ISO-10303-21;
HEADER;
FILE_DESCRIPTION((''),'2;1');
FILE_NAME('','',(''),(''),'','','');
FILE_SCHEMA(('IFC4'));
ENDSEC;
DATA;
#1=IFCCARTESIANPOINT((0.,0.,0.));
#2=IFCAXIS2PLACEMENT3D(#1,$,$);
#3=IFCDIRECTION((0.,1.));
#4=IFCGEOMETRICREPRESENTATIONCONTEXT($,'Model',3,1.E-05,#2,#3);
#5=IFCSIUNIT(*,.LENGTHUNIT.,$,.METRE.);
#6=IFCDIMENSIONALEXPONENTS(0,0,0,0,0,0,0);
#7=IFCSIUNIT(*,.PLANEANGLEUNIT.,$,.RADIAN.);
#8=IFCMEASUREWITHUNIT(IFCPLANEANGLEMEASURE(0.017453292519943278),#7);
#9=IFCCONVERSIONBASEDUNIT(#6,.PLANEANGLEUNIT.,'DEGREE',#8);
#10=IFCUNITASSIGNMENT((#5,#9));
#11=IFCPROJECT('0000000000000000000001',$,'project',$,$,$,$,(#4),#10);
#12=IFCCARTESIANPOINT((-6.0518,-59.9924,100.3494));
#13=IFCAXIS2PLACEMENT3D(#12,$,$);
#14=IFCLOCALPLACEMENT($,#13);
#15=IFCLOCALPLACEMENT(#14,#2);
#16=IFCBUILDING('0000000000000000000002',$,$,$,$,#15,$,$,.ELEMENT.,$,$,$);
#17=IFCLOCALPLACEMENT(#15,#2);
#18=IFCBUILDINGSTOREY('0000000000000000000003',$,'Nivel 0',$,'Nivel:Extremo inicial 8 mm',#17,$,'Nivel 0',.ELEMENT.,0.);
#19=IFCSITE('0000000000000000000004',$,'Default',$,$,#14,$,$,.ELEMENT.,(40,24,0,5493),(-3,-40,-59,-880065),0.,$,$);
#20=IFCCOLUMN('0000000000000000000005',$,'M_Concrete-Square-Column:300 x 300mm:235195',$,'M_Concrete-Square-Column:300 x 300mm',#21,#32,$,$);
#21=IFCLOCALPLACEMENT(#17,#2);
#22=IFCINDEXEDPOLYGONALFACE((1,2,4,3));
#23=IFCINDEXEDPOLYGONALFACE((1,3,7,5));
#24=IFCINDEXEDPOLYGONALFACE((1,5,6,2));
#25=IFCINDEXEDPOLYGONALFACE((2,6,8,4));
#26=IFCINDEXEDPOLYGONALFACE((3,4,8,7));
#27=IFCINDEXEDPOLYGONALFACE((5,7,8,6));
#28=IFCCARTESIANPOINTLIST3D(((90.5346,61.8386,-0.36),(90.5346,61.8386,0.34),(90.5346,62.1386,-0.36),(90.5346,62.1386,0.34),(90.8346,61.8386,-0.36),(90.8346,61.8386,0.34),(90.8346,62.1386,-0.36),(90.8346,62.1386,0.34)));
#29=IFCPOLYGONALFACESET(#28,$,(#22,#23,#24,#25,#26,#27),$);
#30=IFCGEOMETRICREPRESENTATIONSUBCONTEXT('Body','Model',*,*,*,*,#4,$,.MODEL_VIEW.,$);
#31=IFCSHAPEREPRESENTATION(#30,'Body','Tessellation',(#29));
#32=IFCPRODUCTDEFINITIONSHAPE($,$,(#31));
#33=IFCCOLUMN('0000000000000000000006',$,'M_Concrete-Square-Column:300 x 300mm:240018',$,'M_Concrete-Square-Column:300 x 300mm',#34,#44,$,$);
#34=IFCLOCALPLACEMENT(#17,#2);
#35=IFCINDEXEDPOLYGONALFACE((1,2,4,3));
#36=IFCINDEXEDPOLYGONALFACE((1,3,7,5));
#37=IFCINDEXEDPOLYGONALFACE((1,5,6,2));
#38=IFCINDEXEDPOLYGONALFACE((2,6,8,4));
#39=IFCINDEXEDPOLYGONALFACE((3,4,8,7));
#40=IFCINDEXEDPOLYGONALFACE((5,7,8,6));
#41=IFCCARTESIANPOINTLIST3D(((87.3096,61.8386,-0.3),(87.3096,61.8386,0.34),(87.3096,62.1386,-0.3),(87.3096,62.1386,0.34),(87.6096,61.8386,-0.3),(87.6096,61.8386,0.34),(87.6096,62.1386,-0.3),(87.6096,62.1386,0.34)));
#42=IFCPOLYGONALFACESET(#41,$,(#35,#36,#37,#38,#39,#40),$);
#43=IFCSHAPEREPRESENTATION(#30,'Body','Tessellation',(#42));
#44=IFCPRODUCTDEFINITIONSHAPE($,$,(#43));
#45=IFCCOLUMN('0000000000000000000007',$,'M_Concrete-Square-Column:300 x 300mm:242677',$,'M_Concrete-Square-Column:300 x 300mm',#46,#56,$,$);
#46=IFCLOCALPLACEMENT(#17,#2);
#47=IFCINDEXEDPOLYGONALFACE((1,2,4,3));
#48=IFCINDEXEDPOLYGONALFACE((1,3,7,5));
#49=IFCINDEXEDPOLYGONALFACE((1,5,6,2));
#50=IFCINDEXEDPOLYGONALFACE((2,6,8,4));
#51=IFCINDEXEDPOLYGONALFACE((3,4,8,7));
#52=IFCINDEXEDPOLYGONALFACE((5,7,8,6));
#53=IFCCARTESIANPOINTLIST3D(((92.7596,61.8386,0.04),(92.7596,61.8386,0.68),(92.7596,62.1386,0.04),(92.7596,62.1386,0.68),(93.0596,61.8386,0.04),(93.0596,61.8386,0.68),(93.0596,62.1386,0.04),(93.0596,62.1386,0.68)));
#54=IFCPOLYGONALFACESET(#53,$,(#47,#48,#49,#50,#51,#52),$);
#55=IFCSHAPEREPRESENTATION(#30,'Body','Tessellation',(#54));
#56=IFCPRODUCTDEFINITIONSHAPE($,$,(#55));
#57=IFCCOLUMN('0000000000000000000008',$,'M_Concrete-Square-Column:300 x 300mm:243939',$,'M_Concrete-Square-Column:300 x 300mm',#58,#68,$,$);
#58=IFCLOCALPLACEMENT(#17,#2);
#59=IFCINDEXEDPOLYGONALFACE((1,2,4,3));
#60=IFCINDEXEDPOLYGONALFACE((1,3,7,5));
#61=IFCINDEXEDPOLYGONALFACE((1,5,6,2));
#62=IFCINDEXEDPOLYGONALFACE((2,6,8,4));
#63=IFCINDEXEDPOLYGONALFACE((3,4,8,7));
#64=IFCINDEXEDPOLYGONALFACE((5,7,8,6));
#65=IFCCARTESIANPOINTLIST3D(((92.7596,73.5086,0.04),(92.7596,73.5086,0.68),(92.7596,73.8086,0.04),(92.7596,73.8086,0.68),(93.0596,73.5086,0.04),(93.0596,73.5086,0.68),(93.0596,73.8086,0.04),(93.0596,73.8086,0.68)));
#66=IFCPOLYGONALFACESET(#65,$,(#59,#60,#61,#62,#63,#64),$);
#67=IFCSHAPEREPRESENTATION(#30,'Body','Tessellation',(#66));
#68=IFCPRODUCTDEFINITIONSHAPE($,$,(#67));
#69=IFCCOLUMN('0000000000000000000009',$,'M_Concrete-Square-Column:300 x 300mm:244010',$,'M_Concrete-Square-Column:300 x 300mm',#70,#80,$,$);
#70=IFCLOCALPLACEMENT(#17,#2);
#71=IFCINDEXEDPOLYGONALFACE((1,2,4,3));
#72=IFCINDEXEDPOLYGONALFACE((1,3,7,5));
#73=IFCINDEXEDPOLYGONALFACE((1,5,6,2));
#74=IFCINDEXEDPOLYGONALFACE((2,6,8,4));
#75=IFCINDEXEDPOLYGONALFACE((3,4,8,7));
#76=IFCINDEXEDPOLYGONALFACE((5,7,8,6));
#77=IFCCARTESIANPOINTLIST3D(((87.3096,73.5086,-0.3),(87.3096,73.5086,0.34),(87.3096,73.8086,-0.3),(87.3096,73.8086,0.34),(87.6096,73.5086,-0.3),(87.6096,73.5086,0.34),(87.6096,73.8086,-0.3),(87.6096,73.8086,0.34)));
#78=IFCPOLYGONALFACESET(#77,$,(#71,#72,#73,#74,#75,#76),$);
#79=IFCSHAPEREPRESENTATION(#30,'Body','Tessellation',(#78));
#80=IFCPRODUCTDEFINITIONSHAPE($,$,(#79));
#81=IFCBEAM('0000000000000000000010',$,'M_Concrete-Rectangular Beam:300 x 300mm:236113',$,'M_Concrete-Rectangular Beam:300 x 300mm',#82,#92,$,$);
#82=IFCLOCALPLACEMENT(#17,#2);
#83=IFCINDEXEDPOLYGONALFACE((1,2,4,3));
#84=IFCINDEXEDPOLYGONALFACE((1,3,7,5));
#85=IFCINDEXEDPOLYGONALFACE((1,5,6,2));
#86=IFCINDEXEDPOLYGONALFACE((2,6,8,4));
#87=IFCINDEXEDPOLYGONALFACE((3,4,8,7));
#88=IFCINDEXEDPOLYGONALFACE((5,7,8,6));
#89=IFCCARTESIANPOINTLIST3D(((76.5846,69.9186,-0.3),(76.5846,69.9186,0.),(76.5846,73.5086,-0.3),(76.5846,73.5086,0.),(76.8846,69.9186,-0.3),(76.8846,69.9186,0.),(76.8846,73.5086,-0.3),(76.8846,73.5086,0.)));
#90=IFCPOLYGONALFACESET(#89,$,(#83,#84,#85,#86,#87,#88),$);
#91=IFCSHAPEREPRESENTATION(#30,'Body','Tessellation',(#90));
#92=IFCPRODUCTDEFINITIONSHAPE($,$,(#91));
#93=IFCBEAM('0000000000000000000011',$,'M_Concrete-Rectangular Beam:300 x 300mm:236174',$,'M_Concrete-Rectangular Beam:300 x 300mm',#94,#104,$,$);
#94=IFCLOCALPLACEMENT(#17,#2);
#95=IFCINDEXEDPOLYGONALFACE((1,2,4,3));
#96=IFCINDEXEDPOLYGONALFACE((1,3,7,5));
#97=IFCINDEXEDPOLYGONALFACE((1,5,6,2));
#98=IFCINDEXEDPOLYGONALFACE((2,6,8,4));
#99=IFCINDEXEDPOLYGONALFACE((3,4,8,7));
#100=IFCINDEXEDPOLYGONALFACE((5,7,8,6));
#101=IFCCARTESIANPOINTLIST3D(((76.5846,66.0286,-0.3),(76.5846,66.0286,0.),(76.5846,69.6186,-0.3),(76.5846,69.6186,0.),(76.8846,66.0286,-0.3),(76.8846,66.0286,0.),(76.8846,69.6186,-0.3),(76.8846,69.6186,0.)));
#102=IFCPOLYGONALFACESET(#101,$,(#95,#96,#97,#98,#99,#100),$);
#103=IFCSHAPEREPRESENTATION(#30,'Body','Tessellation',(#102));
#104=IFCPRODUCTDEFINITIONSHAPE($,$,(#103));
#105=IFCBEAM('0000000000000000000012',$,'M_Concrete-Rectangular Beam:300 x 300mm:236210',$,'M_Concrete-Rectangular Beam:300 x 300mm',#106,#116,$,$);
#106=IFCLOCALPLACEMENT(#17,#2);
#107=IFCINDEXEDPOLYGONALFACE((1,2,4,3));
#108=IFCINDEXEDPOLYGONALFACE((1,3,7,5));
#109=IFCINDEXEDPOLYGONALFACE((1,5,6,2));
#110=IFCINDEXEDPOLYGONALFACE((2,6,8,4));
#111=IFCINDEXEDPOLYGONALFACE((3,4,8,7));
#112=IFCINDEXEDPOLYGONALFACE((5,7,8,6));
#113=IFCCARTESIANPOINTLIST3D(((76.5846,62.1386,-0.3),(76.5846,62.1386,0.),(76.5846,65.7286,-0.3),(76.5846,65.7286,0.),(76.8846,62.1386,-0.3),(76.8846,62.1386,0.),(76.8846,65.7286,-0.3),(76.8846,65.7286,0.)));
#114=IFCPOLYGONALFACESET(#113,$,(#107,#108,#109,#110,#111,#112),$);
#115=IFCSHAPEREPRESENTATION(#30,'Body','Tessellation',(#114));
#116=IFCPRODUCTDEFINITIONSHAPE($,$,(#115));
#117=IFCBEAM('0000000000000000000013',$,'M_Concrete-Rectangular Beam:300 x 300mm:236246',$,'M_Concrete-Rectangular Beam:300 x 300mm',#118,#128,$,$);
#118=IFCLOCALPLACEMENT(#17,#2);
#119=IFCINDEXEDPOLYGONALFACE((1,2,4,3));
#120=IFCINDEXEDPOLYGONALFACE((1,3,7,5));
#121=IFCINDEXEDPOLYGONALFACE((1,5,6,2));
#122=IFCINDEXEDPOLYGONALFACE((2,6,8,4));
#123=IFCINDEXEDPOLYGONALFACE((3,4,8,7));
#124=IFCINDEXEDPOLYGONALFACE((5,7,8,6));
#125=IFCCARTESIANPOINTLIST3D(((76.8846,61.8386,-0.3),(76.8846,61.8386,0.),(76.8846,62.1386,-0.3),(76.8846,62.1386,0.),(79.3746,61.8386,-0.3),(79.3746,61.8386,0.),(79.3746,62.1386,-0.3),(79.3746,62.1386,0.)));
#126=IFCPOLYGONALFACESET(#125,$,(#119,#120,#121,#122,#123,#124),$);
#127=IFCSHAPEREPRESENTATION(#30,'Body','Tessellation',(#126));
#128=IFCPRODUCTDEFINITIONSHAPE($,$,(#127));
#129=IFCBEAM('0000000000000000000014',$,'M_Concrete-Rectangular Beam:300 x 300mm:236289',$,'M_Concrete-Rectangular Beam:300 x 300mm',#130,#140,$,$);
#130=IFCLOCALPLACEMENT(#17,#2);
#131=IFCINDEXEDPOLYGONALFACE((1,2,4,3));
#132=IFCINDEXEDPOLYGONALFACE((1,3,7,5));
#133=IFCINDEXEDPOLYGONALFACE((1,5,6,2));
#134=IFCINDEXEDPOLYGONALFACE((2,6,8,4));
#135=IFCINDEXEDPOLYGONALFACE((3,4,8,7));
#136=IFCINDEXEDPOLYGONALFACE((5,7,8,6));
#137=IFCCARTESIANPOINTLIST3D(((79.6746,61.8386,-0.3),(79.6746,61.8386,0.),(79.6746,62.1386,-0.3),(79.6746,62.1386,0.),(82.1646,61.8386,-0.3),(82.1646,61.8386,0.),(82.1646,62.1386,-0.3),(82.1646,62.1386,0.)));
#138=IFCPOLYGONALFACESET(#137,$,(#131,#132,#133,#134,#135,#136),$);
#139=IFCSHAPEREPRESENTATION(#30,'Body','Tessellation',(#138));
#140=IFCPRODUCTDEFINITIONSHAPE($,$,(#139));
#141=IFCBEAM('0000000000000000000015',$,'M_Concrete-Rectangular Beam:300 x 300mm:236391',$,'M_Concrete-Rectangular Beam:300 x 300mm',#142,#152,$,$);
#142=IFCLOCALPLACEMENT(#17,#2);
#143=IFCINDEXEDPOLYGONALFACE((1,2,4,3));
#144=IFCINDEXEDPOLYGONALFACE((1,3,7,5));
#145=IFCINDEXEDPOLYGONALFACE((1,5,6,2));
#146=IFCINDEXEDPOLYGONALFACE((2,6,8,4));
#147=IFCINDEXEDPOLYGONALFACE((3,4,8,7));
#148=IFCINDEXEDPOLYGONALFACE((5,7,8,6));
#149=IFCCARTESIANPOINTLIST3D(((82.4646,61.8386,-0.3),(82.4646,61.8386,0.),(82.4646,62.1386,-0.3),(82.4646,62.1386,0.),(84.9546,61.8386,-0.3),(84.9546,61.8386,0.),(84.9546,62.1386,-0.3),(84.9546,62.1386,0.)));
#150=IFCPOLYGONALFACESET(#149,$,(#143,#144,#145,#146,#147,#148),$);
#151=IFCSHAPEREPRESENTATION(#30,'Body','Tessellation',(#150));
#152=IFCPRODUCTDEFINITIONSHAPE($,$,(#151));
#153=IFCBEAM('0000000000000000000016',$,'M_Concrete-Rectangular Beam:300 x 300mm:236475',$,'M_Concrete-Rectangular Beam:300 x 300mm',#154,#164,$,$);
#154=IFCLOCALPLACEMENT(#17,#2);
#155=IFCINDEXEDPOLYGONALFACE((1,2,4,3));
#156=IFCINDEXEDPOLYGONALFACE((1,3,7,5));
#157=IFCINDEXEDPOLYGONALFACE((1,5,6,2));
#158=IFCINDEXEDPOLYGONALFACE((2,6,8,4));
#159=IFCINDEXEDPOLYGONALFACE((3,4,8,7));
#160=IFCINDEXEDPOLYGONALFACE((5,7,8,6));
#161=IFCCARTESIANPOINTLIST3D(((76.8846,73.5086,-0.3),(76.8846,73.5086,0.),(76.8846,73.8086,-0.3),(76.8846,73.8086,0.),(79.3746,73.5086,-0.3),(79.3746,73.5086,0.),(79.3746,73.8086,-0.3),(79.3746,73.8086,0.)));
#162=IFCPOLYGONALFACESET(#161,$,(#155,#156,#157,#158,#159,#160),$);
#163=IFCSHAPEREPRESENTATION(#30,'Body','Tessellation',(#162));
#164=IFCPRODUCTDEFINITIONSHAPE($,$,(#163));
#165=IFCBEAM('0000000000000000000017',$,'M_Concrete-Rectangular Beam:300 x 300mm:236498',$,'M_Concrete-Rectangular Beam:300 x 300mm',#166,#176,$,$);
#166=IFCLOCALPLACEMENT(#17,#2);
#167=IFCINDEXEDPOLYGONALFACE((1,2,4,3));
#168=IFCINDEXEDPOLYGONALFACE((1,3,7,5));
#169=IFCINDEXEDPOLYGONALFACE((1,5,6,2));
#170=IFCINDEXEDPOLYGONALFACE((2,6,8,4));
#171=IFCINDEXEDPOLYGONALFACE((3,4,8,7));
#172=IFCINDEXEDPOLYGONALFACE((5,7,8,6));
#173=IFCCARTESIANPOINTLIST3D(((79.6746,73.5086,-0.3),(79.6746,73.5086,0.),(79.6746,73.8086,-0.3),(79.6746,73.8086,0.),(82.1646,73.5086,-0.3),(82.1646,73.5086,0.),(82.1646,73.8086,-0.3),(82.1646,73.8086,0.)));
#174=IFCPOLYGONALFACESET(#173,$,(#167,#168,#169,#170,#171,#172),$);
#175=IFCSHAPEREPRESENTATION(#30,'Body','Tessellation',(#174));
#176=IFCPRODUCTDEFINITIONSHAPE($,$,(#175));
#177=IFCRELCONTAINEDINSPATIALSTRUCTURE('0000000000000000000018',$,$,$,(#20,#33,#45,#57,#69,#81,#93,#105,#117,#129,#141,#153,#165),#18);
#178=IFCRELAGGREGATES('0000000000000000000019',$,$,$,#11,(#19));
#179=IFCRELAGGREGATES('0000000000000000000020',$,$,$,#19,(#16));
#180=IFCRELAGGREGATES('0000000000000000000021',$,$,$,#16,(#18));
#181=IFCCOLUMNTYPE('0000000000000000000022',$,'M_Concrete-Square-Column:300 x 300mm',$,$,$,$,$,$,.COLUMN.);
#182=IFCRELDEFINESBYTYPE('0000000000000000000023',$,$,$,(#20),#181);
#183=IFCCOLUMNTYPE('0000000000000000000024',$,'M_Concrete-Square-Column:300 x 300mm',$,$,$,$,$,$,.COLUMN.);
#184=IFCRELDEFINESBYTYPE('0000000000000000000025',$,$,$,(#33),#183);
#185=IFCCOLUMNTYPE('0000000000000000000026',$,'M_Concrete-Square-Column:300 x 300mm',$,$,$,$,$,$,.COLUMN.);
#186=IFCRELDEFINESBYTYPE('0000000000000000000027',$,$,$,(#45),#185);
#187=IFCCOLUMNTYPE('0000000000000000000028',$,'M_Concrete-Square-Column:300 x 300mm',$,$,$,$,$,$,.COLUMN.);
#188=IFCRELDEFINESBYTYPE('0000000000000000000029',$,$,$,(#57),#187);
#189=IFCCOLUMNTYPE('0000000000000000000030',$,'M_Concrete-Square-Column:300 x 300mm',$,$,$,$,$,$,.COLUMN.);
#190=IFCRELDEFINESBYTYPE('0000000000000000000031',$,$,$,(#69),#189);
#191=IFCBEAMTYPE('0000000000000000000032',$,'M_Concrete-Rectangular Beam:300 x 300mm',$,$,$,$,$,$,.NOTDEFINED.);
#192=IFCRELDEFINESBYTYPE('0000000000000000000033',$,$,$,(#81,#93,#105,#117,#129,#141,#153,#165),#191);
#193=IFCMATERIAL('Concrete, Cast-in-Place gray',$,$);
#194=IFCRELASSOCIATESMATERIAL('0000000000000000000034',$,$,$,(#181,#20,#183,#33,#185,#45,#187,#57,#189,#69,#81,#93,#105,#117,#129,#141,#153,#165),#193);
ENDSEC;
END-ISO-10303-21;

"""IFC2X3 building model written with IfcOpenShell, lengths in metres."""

from ifc_helpers import new_model, entity, si_unit, converted_unit, direction, frame, frame_2d, origin, origin_2d_with_axis, place, context, subcontext, project, spatial, rectangle, extrude, source, transform, mapped, material, type_object, type_shapes, element, save


model = new_model("IFC2X3")

# Units and contexts
model_context = context("Model", 3, precision=1e-05, world=origin(), true_north=direction((0.0, 1.0)))
body_context = subcontext(model_context, "Body", "Model", "MODEL_VIEW")
ifc_project = project(units=[si_unit("LENGTHUNIT", "METRE"), converted_unit("PLANEANGLEUNIT", "DEGREE", entity("IfcPlaneAngleMeasure", 0.017453292519943278), si_unit("PLANEANGLEUNIT", "RADIAN"), dimensions=[0, 0, 0, 0, 0, 0, 0])], contexts=[model_context])

# Site, building, storey
site_placement = place(None, frame((-6.0518, -59.9924, 100.3494)))
site = spatial("IfcSite", under=ifc_project, at=site_placement, Name="Default", CompositionType="ELEMENT", RefLatitude=(40, 24, 0, 5493), RefLongitude=(-3, -40, -59, -880065), RefElevation=0.0)
building_placement = place(site_placement, origin())
building = spatial("IfcBuilding", under=site, at=building_placement, CompositionType="ELEMENT")
storey_placement = place(building_placement, origin())
storey = spatial("IfcBuildingStorey", under=building, at=storey_placement, Name="Nivel 0", ObjectType="Nivel:Extremo inicial 8 mm", LongName="Nivel 0", CompositionType="ELEMENT", Elevation=0.0)

# Columns
ifc_material = material(Name="Concrete, Cast-in-Place gray")
column_type_1 = type_object("IfcColumnType", Name="M_Concrete-Square-Column:300 x 300mm", PredefinedType="COLUMN", material=ifc_material)
shared_shape_1 = source(origin(), body_context, "Body", "SweptSolid", [
    extrude(rectangle(XDim=0.3, YDim=0.3, at=origin_2d_with_axis()), frame((90.6846, 61.9886, -0.36), z_axis=(0.0, 0.0, 1.0), x_axis=(-1.0, 0.0, 0.0)), (0.0, 0.0, 1.0), 0.7),
])
type_shapes(column_type_1, [shared_shape_1])
column_1_placement = place(storey_placement, origin())
element("IfcColumn", 1, at=column_1_placement, inside=storey, type_object=column_type_1, material=ifc_material, Name="M_Concrete-Square-Column:300 x 300mm:235195", ObjectType="M_Concrete-Square-Column:300 x 300mm", context=body_context, shape_type="MappedRepresentation", body=[
    mapped(shared_shape_1, transform((0.0, 0.0, 0.0), scale=1.0)),
])
column_type_2 = type_object("IfcColumnType", Name="M_Concrete-Square-Column:300 x 300mm", PredefinedType="COLUMN", material=ifc_material)
shared_shape_2 = source(origin(), body_context, "Body", "SweptSolid", [
    extrude(rectangle(XDim=0.3, YDim=0.3, at=origin_2d_with_axis()), frame((87.4596, 61.9886, -0.3), z_axis=(0.0, 0.0, 1.0), x_axis=(-1.0, 0.0, 0.0)), (0.0, 0.0, 1.0), 0.64),
])
type_shapes(column_type_2, [shared_shape_2])
column_2_placement = place(storey_placement, origin())
element("IfcColumn", 2, at=column_2_placement, inside=storey, type_object=column_type_2, material=ifc_material, Name="M_Concrete-Square-Column:300 x 300mm:240018", ObjectType="M_Concrete-Square-Column:300 x 300mm", context=body_context, shape_type="MappedRepresentation", body=[
    mapped(shared_shape_2, transform((0.0, 0.0, 0.0), scale=1.0)),
])
column_type_3 = type_object("IfcColumnType", Name="M_Concrete-Square-Column:300 x 300mm", PredefinedType="COLUMN", material=ifc_material)
shared_shape_3 = source(origin(), body_context, "Body", "SweptSolid", [
    extrude(rectangle(XDim=0.3, YDim=0.3, at=origin_2d_with_axis()), frame((92.9096, 61.9886, 0.04), z_axis=(0.0, 0.0, 1.0), x_axis=(-1.0, 0.0, 0.0)), (0.0, 0.0, 1.0), 0.64),
])
type_shapes(column_type_3, [shared_shape_3])
column_3_placement = place(storey_placement, origin())
element("IfcColumn", 3, at=column_3_placement, inside=storey, type_object=column_type_3, material=ifc_material, Name="M_Concrete-Square-Column:300 x 300mm:242677", ObjectType="M_Concrete-Square-Column:300 x 300mm", context=body_context, shape_type="MappedRepresentation", body=[
    mapped(shared_shape_3, transform((0.0, 0.0, 0.0), scale=1.0)),
])
column_type_4 = type_object("IfcColumnType", Name="M_Concrete-Square-Column:300 x 300mm", PredefinedType="COLUMN", material=ifc_material)
shared_shape_4 = source(origin(), body_context, "Body", "SweptSolid", [
    extrude(rectangle(XDim=0.3, YDim=0.3, at=origin_2d_with_axis()), frame((92.9096, 73.6586, 0.04), z_axis=(0.0, 0.0, 1.0), x_axis=(-1.0, 0.0, 0.0)), (0.0, 0.0, 1.0), 0.64),
])
type_shapes(column_type_4, [shared_shape_4])
column_4_placement = place(storey_placement, origin())
element("IfcColumn", 4, at=column_4_placement, inside=storey, type_object=column_type_4, material=ifc_material, Name="M_Concrete-Square-Column:300 x 300mm:243939", ObjectType="M_Concrete-Square-Column:300 x 300mm", context=body_context, shape_type="MappedRepresentation", body=[
    mapped(shared_shape_4, transform((0.0, 0.0, 0.0), scale=1.0)),
])
column_type_5 = type_object("IfcColumnType", Name="M_Concrete-Square-Column:300 x 300mm", PredefinedType="COLUMN", material=ifc_material)
shared_shape_5 = source(origin(), body_context, "Body", "SweptSolid", [
    extrude(rectangle(XDim=0.3, YDim=0.3, at=origin_2d_with_axis()), frame((87.4596, 73.6586, -0.3), z_axis=(0.0, 0.0, 1.0), x_axis=(-1.0, 0.0, 0.0)), (0.0, 0.0, 1.0), 0.64),
])
type_shapes(column_type_5, [shared_shape_5])
column_5_placement = place(storey_placement, origin())
element("IfcColumn", 5, at=column_5_placement, inside=storey, type_object=column_type_5, material=ifc_material, Name="M_Concrete-Square-Column:300 x 300mm:244010", ObjectType="M_Concrete-Square-Column:300 x 300mm", context=body_context, shape_type="MappedRepresentation", body=[
    mapped(shared_shape_5, transform((0.0, 0.0, 0.0), scale=1.0)),
])

# Beams
beam_type = type_object("IfcBeamType", Name="M_Concrete-Rectangular Beam:300 x 300mm", PredefinedType="NOTDEFINED")
beam_1_placement = place(storey_placement, frame((76.7346, 73.6586, 0.0), z_axis=(0.0, 0.0, 1.0), x_axis=(0.0, -1.0, 0.0)))
element("IfcBeam", 6, at=beam_1_placement, inside=storey, type_object=beam_type, material=ifc_material, Name="M_Concrete-Rectangular Beam:300 x 300mm:236113", ObjectType="M_Concrete-Rectangular Beam:300 x 300mm", context=body_context, shape_type="SweptSolid", body=[
    extrude(rectangle(XDim=0.3, YDim=0.3, at=frame_2d((0.0, 0.0), x_axis=(1.0, 0.0))), frame((0.15, 0.0, -0.15), z_axis=(1.0, 0.0, 0.0), x_axis=(0.0, 0.0, -1.0)), (0.0, 0.0, 1.0), 3.59),
])
beam_2_placement = place(storey_placement, frame((76.7346, 69.7686, 0.0), z_axis=(0.0, 0.0, 1.0), x_axis=(0.0, -1.0, 0.0)))
element("IfcBeam", 7, at=beam_2_placement, inside=storey, type_object=beam_type, material=ifc_material, Name="M_Concrete-Rectangular Beam:300 x 300mm:236174", ObjectType="M_Concrete-Rectangular Beam:300 x 300mm", context=body_context, shape_type="SweptSolid", body=[
    extrude(rectangle(XDim=0.3, YDim=0.3, at=frame_2d((0.0, 0.0), x_axis=(1.0, 0.0))), frame((0.15, 0.0, -0.15), z_axis=(1.0, 0.0, 0.0), x_axis=(0.0, 0.0, -1.0)), (0.0, 0.0, 1.0), 3.59),
])
beam_3_placement = place(storey_placement, frame((76.7346, 65.8786, 0.0), z_axis=(0.0, 0.0, 1.0), x_axis=(0.0, -1.0, 0.0)))
element("IfcBeam", 8, at=beam_3_placement, inside=storey, type_object=beam_type, material=ifc_material, Name="M_Concrete-Rectangular Beam:300 x 300mm:236210", ObjectType="M_Concrete-Rectangular Beam:300 x 300mm", context=body_context, shape_type="SweptSolid", body=[
    extrude(rectangle(XDim=0.3, YDim=0.3, at=frame_2d((0.0, 0.0), x_axis=(1.0, 0.0))), frame((0.15, 0.0, -0.15), z_axis=(1.0, 0.0, 0.0), x_axis=(0.0, 0.0, -1.0)), (0.0, 0.0, 1.0), 3.59),
])
beam_4_placement = place(storey_placement, frame((76.7346, 61.9886, 0.0)))
element("IfcBeam", 9, at=beam_4_placement, inside=storey, type_object=beam_type, material=ifc_material, Name="M_Concrete-Rectangular Beam:300 x 300mm:236246", ObjectType="M_Concrete-Rectangular Beam:300 x 300mm", context=body_context, shape_type="SweptSolid", body=[
    extrude(rectangle(XDim=0.3, YDim=0.3, at=frame_2d((0.0, 0.0), x_axis=(1.0, 0.0))), frame((0.15, 0.0, -0.15), z_axis=(1.0, 0.0, 0.0), x_axis=(0.0, 0.0, -1.0)), (0.0, 0.0, 1.0), 2.49),
])
beam_5_placement = place(storey_placement, frame((79.5246, 61.9886, 0.0)))
element("IfcBeam", 10, at=beam_5_placement, inside=storey, type_object=beam_type, material=ifc_material, Name="M_Concrete-Rectangular Beam:300 x 300mm:236289", ObjectType="M_Concrete-Rectangular Beam:300 x 300mm", context=body_context, shape_type="SweptSolid", body=[
    extrude(rectangle(XDim=0.3, YDim=0.3, at=frame_2d((0.0, 0.0), x_axis=(1.0, 0.0))), frame((0.15, 0.0, -0.15), z_axis=(1.0, 0.0, 0.0), x_axis=(0.0, 0.0, -1.0)), (0.0, 0.0, 1.0), 2.49),
])
beam_6_placement = place(storey_placement, frame((82.3146, 61.9886, 0.0)))
element("IfcBeam", 11, at=beam_6_placement, inside=storey, type_object=beam_type, material=ifc_material, Name="M_Concrete-Rectangular Beam:300 x 300mm:236391", ObjectType="M_Concrete-Rectangular Beam:300 x 300mm", context=body_context, shape_type="SweptSolid", body=[
    extrude(rectangle(XDim=0.3, YDim=0.3, at=frame_2d((0.0, 0.0), x_axis=(1.0, 0.0))), frame((0.15, 0.0, -0.15), z_axis=(1.0, 0.0, 0.0), x_axis=(0.0, 0.0, -1.0)), (0.0, 0.0, 1.0), 2.49),
])
beam_7_placement = place(storey_placement, frame((76.7346, 73.6586, 0.0)))
element("IfcBeam", 12, at=beam_7_placement, inside=storey, type_object=beam_type, material=ifc_material, Name="M_Concrete-Rectangular Beam:300 x 300mm:236475", ObjectType="M_Concrete-Rectangular Beam:300 x 300mm", context=body_context, shape_type="SweptSolid", body=[
    extrude(rectangle(XDim=0.3, YDim=0.3, at=frame_2d((0.0, 0.0), x_axis=(1.0, 0.0))), frame((0.15, 0.0, -0.15), z_axis=(1.0, 0.0, 0.0), x_axis=(0.0, 0.0, -1.0)), (0.0, 0.0, 1.0), 2.49),
])
for number, where, name in (
    (13, (79.5246, 73.6586, 0.0), "M_Concrete-Rectangular Beam:300 x 300mm:236498"),
):
    element("IfcBeam", number, at=place(storey_placement, frame(where)), inside=storey, type_object=beam_type, material=ifc_material, Name=name, ObjectType="M_Concrete-Rectangular Beam:300 x 300mm", context=body_context, shape_type="SweptSolid", body=[
        extrude(rectangle(XDim=0.3, YDim=0.3, at=frame_2d((0.0, 0.0), x_axis=(1.0, 0.0))), frame((0.15, 0.0, -0.15), z_axis=(1.0, 0.0, 0.0), x_axis=(0.0, 0.0, -1.0)), (0.0, 0.0, 1.0), 2.49),
    ])

save(model, "model.ifc")
